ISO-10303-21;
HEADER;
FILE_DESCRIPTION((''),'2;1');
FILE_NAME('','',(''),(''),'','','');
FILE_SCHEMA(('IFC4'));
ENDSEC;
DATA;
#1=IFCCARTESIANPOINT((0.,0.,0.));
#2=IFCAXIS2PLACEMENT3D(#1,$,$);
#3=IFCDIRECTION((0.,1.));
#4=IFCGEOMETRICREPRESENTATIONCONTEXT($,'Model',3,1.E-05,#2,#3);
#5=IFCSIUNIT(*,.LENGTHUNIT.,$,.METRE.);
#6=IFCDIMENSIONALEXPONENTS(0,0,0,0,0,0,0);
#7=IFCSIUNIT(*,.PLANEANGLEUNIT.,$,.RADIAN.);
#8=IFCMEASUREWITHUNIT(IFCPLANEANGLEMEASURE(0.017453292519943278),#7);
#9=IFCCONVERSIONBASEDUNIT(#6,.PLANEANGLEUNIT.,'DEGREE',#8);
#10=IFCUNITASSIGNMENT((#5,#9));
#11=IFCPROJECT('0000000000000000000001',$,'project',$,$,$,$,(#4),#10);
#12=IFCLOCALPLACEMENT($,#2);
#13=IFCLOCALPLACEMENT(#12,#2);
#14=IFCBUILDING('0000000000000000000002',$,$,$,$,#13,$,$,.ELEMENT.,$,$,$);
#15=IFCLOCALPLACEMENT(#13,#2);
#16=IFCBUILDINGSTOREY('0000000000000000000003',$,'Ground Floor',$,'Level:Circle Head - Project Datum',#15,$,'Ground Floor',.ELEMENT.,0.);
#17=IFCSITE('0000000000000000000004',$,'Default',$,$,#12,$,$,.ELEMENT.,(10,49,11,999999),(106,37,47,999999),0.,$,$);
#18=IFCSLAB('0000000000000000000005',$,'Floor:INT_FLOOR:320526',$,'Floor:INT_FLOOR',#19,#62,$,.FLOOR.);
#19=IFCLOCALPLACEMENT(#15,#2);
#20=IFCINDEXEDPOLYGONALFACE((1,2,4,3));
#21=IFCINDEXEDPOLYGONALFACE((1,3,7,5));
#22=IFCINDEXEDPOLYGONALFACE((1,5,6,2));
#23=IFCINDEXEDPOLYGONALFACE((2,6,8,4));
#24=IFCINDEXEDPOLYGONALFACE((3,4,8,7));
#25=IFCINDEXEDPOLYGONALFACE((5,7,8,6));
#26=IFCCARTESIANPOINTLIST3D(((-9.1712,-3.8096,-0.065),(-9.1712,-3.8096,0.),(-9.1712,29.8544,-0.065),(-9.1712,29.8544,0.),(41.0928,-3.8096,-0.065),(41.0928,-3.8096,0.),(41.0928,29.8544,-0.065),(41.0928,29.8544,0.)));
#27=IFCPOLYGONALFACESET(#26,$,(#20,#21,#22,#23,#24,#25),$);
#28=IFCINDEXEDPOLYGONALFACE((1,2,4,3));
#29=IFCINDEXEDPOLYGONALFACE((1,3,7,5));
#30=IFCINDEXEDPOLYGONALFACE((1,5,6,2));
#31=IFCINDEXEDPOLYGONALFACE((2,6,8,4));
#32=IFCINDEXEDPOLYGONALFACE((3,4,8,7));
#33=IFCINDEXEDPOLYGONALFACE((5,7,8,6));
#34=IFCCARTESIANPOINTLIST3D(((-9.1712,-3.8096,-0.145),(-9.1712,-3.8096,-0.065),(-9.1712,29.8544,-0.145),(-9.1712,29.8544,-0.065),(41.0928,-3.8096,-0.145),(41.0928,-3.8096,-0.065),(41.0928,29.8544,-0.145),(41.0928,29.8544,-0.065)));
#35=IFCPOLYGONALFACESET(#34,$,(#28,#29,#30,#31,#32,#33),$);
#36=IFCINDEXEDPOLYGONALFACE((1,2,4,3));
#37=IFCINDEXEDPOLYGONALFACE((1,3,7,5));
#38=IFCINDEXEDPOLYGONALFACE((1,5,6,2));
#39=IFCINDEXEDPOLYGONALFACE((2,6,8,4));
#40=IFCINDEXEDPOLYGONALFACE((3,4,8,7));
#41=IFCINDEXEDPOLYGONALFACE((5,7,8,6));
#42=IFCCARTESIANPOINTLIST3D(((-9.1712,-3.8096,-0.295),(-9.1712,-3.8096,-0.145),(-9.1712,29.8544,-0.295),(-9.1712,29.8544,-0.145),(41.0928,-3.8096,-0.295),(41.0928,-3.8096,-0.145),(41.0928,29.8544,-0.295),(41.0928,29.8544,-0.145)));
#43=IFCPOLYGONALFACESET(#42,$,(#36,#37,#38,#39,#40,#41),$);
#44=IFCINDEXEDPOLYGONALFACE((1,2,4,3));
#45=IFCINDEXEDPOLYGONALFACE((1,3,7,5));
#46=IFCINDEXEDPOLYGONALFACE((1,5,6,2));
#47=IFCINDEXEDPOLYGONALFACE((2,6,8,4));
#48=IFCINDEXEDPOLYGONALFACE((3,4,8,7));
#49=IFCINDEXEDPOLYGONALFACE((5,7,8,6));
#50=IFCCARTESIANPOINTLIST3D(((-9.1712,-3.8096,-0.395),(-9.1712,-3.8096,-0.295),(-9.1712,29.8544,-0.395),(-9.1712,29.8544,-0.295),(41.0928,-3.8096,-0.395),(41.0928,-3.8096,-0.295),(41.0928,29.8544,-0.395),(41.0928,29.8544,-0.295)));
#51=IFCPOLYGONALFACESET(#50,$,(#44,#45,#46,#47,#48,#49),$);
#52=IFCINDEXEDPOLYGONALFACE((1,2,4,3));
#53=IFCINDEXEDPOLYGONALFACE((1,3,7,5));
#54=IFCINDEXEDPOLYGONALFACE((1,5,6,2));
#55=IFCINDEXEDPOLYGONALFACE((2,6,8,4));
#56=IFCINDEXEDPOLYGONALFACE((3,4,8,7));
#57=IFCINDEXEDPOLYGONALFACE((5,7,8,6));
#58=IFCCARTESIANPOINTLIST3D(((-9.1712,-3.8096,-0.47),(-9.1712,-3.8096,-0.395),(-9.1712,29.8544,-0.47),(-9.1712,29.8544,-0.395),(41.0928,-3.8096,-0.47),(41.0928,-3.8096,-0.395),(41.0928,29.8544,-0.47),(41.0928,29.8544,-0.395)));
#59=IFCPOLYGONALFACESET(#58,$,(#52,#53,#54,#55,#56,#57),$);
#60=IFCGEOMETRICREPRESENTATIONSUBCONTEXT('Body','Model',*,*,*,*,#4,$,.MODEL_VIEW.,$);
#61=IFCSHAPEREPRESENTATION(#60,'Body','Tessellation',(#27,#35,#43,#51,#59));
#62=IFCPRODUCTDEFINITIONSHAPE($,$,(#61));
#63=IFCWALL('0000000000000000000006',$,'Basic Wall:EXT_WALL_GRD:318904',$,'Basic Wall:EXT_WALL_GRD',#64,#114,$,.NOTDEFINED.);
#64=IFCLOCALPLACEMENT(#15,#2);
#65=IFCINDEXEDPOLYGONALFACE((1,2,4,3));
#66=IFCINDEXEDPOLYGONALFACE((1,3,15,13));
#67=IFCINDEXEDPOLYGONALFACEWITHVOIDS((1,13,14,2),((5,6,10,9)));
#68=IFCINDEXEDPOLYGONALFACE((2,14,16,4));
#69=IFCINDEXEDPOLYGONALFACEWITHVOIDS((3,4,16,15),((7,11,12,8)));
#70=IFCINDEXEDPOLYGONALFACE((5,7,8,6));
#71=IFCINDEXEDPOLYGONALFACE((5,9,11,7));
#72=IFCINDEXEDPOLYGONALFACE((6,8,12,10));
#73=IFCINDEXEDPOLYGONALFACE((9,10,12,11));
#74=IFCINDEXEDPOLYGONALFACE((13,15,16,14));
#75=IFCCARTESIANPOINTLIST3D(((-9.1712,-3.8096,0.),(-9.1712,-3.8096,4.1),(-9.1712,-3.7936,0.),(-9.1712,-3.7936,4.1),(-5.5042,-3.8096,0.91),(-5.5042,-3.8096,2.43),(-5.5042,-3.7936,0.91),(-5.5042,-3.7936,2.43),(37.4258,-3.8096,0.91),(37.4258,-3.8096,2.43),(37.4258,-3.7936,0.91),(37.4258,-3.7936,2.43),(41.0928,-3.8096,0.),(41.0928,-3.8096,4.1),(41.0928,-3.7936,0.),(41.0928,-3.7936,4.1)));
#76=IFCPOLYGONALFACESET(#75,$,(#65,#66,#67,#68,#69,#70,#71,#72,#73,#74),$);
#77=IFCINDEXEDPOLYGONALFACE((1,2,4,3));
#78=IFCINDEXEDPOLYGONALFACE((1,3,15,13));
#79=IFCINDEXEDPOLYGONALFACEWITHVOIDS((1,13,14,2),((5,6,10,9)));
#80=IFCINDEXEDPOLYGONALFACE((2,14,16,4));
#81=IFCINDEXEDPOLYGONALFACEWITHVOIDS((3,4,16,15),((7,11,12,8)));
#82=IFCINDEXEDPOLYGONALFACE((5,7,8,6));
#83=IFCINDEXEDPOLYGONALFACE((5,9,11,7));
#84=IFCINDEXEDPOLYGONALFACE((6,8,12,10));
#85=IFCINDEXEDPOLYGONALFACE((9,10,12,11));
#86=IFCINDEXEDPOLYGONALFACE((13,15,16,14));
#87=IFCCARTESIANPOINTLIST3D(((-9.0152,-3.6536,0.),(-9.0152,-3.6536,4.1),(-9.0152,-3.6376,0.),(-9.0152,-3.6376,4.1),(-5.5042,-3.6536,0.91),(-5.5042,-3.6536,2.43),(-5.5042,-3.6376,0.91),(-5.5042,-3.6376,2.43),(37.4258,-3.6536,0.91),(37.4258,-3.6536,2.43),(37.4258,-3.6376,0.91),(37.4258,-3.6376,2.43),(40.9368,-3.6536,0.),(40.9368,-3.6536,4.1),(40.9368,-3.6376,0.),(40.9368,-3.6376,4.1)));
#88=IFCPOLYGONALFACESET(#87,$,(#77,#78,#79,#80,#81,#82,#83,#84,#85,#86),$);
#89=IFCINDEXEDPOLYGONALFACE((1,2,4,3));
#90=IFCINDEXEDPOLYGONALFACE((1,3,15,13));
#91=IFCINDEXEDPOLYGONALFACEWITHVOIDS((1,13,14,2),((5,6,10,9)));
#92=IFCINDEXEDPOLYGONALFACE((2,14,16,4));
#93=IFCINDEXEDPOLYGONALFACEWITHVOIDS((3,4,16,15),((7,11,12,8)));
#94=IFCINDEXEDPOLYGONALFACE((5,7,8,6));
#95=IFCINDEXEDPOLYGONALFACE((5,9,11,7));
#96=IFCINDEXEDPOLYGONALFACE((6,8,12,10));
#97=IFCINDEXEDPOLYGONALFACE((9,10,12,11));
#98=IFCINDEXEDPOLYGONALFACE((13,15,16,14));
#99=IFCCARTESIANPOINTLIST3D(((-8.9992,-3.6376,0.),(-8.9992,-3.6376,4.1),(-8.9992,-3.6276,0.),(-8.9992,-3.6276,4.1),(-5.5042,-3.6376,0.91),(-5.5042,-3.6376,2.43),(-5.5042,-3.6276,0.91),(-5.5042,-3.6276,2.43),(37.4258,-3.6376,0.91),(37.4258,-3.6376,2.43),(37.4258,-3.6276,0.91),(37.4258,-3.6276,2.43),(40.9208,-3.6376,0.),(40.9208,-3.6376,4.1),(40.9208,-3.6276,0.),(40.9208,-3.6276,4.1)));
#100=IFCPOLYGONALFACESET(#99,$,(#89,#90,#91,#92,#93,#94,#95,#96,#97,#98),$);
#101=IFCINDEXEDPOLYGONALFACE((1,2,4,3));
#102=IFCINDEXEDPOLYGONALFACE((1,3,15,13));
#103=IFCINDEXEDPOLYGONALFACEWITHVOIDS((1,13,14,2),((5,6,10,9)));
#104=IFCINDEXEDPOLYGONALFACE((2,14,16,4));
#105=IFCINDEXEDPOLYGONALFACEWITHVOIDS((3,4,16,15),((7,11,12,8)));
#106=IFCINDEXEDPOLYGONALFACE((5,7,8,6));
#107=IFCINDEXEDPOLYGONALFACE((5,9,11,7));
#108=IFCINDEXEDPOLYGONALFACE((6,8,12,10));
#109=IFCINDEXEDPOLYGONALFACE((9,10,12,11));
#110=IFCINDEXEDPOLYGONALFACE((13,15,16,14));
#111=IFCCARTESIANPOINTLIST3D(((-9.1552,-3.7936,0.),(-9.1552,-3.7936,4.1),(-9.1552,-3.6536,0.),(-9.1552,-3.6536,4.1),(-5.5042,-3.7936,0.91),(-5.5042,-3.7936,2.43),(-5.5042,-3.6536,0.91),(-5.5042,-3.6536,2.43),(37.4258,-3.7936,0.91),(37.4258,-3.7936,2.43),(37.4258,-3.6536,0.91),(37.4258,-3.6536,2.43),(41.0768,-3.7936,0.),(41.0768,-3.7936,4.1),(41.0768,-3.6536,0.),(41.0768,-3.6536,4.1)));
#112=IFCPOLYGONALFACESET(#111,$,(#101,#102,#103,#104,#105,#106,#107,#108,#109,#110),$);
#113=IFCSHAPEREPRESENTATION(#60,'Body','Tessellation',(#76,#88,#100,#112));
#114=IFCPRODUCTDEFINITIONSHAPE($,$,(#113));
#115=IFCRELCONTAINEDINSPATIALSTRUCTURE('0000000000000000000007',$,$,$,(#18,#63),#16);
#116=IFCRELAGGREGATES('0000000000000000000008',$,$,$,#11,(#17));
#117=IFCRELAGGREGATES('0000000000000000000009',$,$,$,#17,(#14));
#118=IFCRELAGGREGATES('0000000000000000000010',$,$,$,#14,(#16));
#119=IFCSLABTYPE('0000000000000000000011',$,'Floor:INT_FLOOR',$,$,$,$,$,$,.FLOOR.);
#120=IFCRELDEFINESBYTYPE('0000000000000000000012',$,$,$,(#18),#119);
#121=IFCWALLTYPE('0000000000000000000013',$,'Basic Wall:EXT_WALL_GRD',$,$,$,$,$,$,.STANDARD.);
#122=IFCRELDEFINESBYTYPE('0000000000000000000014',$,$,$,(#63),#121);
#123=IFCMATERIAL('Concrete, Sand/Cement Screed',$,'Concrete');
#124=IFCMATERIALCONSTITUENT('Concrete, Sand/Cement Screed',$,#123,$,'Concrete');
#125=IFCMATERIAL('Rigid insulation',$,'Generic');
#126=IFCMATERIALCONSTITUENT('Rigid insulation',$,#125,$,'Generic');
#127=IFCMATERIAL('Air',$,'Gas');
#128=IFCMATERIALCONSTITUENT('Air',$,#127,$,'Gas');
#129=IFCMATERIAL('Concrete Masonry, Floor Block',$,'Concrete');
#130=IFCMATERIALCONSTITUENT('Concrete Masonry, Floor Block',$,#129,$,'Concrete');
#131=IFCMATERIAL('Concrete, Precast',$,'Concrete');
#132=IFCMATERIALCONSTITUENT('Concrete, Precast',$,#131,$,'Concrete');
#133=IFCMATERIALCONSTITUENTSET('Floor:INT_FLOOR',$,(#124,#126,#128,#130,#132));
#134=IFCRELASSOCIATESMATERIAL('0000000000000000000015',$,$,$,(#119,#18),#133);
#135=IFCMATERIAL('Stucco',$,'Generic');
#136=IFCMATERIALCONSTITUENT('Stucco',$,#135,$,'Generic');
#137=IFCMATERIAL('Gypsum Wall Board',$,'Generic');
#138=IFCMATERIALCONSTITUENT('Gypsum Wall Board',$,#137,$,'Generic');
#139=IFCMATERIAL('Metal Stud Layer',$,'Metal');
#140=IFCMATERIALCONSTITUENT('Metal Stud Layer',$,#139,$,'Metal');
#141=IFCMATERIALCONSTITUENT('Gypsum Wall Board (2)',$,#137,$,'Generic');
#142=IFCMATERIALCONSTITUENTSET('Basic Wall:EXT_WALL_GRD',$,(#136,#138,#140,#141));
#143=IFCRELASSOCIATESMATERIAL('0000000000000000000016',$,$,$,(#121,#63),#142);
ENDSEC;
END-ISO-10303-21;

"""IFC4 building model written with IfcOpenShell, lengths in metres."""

from ifc_helpers import new_model, entity, si_unit, converted_unit, direction, frame, origin, place, context, subcontext, project, spatial, indexed_curve, outline, extrude, material, constituent, constituent_set, type_object, element, save


model = new_model("IFC4")

# Units and contexts
model_context = context("Model", 3, precision=1e-05, world=origin(), true_north=direction((0.0, 1.0)))
body_context = subcontext(model_context, "Body", "Model", "MODEL_VIEW")
ifc_project = project(units=[si_unit("LENGTHUNIT", "METRE"), converted_unit("PLANEANGLEUNIT", "DEGREE", entity("IfcPlaneAngleMeasure", 0.017453292519943278), si_unit("PLANEANGLEUNIT", "RADIAN"), dimensions=[0, 0, 0, 0, 0, 0, 0])], contexts=[model_context])

# Site, building, storey
site_placement = place(None, origin())
site = spatial("IfcSite", under=ifc_project, at=site_placement, Name="Default", CompositionType="ELEMENT", RefLatitude=(10, 49, 11, 999999), RefLongitude=(106, 37, 47, 999999), RefElevation=0.0)
building_placement = place(site_placement, origin())
building = spatial("IfcBuilding", under=site, at=building_placement, CompositionType="ELEMENT")
storey_placement = place(building_placement, origin())
storey = spatial("IfcBuildingStorey", under=building, at=storey_placement, Name="Ground Floor", ObjectType="Level:Circle Head - Project Datum", LongName="Ground Floor", CompositionType="ELEMENT", Elevation=0.0)

# Slab
ifc_material_1 = material(Name="Concrete, Sand/Cement Screed", Category="Concrete")
ifc_constituent_1 = constituent(ifc_material_1, Name="Concrete, Sand/Cement Screed", Category="Concrete")
ifc_material_2 = material(Name="Rigid insulation", Category="Generic")
ifc_constituent_2 = constituent(ifc_material_2, Name="Rigid insulation", Category="Generic")
ifc_material_3 = material(Name="Air", Category="Gas")
ifc_constituent_3 = constituent(ifc_material_3, Name="Air", Category="Gas")
ifc_material_4 = material(Name="Concrete Masonry, Floor Block", Category="Concrete")
ifc_constituent_4 = constituent(ifc_material_4, Name="Concrete Masonry, Floor Block", Category="Concrete")
ifc_material_5 = material(Name="Concrete, Precast", Category="Concrete")
ifc_constituent_5 = constituent(ifc_material_5, Name="Concrete, Precast", Category="Concrete")
ifc_constituent_set_1 = constituent_set(constituents=[ifc_constituent_1, ifc_constituent_2, ifc_constituent_3, ifc_constituent_4, ifc_constituent_5], Name="Floor:INT_FLOOR")
slab_type = type_object("IfcSlabType", Name="Floor:INT_FLOOR", PredefinedType="FLOOR", material=ifc_constituent_set_1)
slab_placement = place(storey_placement, origin())
element("IfcSlab", 1, at=slab_placement, inside=storey, type_object=slab_type, material=ifc_constituent_set_1, Name="Floor:INT_FLOOR:320526", ObjectType="Floor:INT_FLOOR", PredefinedType="FLOOR", context=body_context, shape_type="SweptSolid", body=[
    extrude(outline(indexed_curve([(-25.132, -16.832), (25.132, -16.832), (25.132, 16.832), (-25.132, 16.832), (-25.132, -16.832)], self_intersect=False)), frame((15.9608, 13.0224, -0.065), z_axis=(0.0, 0.0, 1.0), x_axis=(-1.0, 0.0, 0.0)), (0.0, 0.0, 1.0), 0.065),
    extrude(outline(indexed_curve([(-25.132, -16.832), (25.132, -16.832), (25.132, 16.832), (-25.132, 16.832), (-25.132, -16.832)], self_intersect=False)), frame((15.9608, 13.0224, -0.145), z_axis=(0.0, 0.0, 1.0), x_axis=(-1.0, 0.0, 0.0)), (0.0, 0.0, 1.0), 0.08),
    extrude(outline(indexed_curve([(-25.132, -16.832), (25.132, -16.832), (25.132, 16.832), (-25.132, 16.832), (-25.132, -16.832)], self_intersect=False)), frame((15.9608, 13.0224, -0.295), z_axis=(0.0, 0.0, 1.0), x_axis=(-1.0, 0.0, 0.0)), (0.0, 0.0, 1.0), 0.15),
    extrude(outline(indexed_curve([(-25.132, -16.832), (25.132, -16.832), (25.132, 16.832), (-25.132, 16.832), (-25.132, -16.832)], self_intersect=False)), frame((15.9608, 13.0224, -0.395), z_axis=(0.0, 0.0, 1.0), x_axis=(-1.0, 0.0, 0.0)), (0.0, 0.0, 1.0), 0.1),
    extrude(outline(indexed_curve([(-25.132, -16.832), (25.132, -16.832), (25.132, 16.832), (-25.132, 16.832), (-25.132, -16.832)], self_intersect=False)), frame((15.9608, 13.0224, -0.47), z_axis=(0.0, 0.0, 1.0), x_axis=(-1.0, 0.0, 0.0)), (0.0, 0.0, 1.0), 0.075),
])

# Wall, opening
ifc_material_6 = material(Name="Stucco", Category="Generic")
ifc_constituent_6 = constituent(ifc_material_6, Name="Stucco", Category="Generic")
ifc_material_7 = material(Name="Gypsum Wall Board", Category="Generic")
ifc_constituent_7 = constituent(ifc_material_7, Name="Gypsum Wall Board", Category="Generic")
ifc_material_8 = material(Name="Metal Stud Layer", Category="Metal")
ifc_constituent_8 = constituent(ifc_material_8, Name="Metal Stud Layer", Category="Metal")
ifc_constituent_9 = constituent(ifc_material_7, Name="Gypsum Wall Board (2)", Category="Generic")
ifc_constituent_set_2 = constituent_set(constituents=[ifc_constituent_6, ifc_constituent_7, ifc_constituent_8, ifc_constituent_9], Name="Basic Wall:EXT_WALL_GRD")
wall_type_1 = type_object("IfcWallType", Name="Basic Wall:EXT_WALL_GRD", PredefinedType="STANDARD", material=ifc_constituent_set_2)
wall_1_placement = place(storey_placement, frame((-9.1712, -3.7186, 0.0)))
wall_1 = element("IfcWall", 2, at=wall_1_placement, inside=storey, type_object=wall_type_1, material=ifc_constituent_set_2, Name="Basic Wall:EXT_WALL_GRD:318904", ObjectType="Basic Wall:EXT_WALL_GRD", PredefinedType="NOTDEFINED", context=body_context, shape_type="SweptSolid", body=[
    extrude(outline(indexed_curve([(-2.05, -25.132), (2.05, -25.132), (2.05, 25.132), (-2.05, 25.132), (-2.05, -25.132)], self_intersect=False), holes=[indexed_curve([(0.38, 21.465), (0.38, -21.465), (-1.14, -21.465), (-1.14, 21.465), (0.38, 21.465)], self_intersect=False)]), frame((25.132, -0.091, 2.05), z_axis=(0.0, 1.0, 0.0), x_axis=(0.0, 0.0, 1.0)), (0.0, 0.0, 1.0), 0.016),
    extrude(outline(indexed_curve([(-2.05, -24.976), (2.05, -24.976), (2.05, 24.976), (-2.05, 24.976), (-2.05, -24.976)], self_intersect=False), holes=[indexed_curve([(0.38, 21.465), (0.38, -21.465), (-1.14, -21.465), (-1.14, 21.465), (0.38, 21.465)], self_intersect=False)]), frame((25.132, 0.065, 2.05), z_axis=(0.0, 1.0, 0.0), x_axis=(0.0, 0.0, 1.0)), (0.0, 0.0, 1.0), 0.016),
    extrude(outline(indexed_curve([(-2.05, -24.96), (2.05, -24.96), (2.05, 24.96), (-2.05, 24.96), (-2.05, -24.96)], self_intersect=False), holes=[indexed_curve([(0.38, 21.465), (0.38, -21.465), (-1.14, -21.465), (-1.14, 21.465), (0.38, 21.465)], self_intersect=False)]), frame((25.132, 0.081, 2.05), z_axis=(0.0, 1.0, 0.0), x_axis=(0.0, 0.0, 1.0)), (0.0, 0.0, 1.0), 0.01),
    extrude(outline(indexed_curve([(-2.05, -25.116), (2.05, -25.116), (2.05, 25.116), (-2.05, 25.116), (-2.05, -25.116)], self_intersect=False), holes=[indexed_curve([(0.38, 21.465), (0.38, -21.465), (-1.14, -21.465), (-1.14, 21.465), (0.38, 21.465)], self_intersect=False)]), frame((25.132, -0.075, 2.05), z_axis=(0.0, 1.0, 0.0), x_axis=(0.0, 0.0, 1.0)), (0.0, 0.0, 1.0), 0.14),
])
opening_1_placement = place(wall_1_placement, frame((46.597, 0.091, 0.91)))
element("IfcOpeningElement", 3, at=opening_1_placement, cuts=wall_1, PredefinedType="OPENING", context=body_context, shape_type="SweptSolid", body=[
    extrude(outline(indexed_curve([(1.52, 0.0), (1.52, 42.93), (0.0, 42.93), (0.0, 0.0), (1.52, 0.0)], self_intersect=False)), frame((0.0, 0.0, 0.0), z_axis=(0.0, -1.0, 0.0), x_axis=(0.0, 0.0, 1.0)), (0.0, 0.0, 1.0), 0.182),
])

save(model, "model.ifc")
